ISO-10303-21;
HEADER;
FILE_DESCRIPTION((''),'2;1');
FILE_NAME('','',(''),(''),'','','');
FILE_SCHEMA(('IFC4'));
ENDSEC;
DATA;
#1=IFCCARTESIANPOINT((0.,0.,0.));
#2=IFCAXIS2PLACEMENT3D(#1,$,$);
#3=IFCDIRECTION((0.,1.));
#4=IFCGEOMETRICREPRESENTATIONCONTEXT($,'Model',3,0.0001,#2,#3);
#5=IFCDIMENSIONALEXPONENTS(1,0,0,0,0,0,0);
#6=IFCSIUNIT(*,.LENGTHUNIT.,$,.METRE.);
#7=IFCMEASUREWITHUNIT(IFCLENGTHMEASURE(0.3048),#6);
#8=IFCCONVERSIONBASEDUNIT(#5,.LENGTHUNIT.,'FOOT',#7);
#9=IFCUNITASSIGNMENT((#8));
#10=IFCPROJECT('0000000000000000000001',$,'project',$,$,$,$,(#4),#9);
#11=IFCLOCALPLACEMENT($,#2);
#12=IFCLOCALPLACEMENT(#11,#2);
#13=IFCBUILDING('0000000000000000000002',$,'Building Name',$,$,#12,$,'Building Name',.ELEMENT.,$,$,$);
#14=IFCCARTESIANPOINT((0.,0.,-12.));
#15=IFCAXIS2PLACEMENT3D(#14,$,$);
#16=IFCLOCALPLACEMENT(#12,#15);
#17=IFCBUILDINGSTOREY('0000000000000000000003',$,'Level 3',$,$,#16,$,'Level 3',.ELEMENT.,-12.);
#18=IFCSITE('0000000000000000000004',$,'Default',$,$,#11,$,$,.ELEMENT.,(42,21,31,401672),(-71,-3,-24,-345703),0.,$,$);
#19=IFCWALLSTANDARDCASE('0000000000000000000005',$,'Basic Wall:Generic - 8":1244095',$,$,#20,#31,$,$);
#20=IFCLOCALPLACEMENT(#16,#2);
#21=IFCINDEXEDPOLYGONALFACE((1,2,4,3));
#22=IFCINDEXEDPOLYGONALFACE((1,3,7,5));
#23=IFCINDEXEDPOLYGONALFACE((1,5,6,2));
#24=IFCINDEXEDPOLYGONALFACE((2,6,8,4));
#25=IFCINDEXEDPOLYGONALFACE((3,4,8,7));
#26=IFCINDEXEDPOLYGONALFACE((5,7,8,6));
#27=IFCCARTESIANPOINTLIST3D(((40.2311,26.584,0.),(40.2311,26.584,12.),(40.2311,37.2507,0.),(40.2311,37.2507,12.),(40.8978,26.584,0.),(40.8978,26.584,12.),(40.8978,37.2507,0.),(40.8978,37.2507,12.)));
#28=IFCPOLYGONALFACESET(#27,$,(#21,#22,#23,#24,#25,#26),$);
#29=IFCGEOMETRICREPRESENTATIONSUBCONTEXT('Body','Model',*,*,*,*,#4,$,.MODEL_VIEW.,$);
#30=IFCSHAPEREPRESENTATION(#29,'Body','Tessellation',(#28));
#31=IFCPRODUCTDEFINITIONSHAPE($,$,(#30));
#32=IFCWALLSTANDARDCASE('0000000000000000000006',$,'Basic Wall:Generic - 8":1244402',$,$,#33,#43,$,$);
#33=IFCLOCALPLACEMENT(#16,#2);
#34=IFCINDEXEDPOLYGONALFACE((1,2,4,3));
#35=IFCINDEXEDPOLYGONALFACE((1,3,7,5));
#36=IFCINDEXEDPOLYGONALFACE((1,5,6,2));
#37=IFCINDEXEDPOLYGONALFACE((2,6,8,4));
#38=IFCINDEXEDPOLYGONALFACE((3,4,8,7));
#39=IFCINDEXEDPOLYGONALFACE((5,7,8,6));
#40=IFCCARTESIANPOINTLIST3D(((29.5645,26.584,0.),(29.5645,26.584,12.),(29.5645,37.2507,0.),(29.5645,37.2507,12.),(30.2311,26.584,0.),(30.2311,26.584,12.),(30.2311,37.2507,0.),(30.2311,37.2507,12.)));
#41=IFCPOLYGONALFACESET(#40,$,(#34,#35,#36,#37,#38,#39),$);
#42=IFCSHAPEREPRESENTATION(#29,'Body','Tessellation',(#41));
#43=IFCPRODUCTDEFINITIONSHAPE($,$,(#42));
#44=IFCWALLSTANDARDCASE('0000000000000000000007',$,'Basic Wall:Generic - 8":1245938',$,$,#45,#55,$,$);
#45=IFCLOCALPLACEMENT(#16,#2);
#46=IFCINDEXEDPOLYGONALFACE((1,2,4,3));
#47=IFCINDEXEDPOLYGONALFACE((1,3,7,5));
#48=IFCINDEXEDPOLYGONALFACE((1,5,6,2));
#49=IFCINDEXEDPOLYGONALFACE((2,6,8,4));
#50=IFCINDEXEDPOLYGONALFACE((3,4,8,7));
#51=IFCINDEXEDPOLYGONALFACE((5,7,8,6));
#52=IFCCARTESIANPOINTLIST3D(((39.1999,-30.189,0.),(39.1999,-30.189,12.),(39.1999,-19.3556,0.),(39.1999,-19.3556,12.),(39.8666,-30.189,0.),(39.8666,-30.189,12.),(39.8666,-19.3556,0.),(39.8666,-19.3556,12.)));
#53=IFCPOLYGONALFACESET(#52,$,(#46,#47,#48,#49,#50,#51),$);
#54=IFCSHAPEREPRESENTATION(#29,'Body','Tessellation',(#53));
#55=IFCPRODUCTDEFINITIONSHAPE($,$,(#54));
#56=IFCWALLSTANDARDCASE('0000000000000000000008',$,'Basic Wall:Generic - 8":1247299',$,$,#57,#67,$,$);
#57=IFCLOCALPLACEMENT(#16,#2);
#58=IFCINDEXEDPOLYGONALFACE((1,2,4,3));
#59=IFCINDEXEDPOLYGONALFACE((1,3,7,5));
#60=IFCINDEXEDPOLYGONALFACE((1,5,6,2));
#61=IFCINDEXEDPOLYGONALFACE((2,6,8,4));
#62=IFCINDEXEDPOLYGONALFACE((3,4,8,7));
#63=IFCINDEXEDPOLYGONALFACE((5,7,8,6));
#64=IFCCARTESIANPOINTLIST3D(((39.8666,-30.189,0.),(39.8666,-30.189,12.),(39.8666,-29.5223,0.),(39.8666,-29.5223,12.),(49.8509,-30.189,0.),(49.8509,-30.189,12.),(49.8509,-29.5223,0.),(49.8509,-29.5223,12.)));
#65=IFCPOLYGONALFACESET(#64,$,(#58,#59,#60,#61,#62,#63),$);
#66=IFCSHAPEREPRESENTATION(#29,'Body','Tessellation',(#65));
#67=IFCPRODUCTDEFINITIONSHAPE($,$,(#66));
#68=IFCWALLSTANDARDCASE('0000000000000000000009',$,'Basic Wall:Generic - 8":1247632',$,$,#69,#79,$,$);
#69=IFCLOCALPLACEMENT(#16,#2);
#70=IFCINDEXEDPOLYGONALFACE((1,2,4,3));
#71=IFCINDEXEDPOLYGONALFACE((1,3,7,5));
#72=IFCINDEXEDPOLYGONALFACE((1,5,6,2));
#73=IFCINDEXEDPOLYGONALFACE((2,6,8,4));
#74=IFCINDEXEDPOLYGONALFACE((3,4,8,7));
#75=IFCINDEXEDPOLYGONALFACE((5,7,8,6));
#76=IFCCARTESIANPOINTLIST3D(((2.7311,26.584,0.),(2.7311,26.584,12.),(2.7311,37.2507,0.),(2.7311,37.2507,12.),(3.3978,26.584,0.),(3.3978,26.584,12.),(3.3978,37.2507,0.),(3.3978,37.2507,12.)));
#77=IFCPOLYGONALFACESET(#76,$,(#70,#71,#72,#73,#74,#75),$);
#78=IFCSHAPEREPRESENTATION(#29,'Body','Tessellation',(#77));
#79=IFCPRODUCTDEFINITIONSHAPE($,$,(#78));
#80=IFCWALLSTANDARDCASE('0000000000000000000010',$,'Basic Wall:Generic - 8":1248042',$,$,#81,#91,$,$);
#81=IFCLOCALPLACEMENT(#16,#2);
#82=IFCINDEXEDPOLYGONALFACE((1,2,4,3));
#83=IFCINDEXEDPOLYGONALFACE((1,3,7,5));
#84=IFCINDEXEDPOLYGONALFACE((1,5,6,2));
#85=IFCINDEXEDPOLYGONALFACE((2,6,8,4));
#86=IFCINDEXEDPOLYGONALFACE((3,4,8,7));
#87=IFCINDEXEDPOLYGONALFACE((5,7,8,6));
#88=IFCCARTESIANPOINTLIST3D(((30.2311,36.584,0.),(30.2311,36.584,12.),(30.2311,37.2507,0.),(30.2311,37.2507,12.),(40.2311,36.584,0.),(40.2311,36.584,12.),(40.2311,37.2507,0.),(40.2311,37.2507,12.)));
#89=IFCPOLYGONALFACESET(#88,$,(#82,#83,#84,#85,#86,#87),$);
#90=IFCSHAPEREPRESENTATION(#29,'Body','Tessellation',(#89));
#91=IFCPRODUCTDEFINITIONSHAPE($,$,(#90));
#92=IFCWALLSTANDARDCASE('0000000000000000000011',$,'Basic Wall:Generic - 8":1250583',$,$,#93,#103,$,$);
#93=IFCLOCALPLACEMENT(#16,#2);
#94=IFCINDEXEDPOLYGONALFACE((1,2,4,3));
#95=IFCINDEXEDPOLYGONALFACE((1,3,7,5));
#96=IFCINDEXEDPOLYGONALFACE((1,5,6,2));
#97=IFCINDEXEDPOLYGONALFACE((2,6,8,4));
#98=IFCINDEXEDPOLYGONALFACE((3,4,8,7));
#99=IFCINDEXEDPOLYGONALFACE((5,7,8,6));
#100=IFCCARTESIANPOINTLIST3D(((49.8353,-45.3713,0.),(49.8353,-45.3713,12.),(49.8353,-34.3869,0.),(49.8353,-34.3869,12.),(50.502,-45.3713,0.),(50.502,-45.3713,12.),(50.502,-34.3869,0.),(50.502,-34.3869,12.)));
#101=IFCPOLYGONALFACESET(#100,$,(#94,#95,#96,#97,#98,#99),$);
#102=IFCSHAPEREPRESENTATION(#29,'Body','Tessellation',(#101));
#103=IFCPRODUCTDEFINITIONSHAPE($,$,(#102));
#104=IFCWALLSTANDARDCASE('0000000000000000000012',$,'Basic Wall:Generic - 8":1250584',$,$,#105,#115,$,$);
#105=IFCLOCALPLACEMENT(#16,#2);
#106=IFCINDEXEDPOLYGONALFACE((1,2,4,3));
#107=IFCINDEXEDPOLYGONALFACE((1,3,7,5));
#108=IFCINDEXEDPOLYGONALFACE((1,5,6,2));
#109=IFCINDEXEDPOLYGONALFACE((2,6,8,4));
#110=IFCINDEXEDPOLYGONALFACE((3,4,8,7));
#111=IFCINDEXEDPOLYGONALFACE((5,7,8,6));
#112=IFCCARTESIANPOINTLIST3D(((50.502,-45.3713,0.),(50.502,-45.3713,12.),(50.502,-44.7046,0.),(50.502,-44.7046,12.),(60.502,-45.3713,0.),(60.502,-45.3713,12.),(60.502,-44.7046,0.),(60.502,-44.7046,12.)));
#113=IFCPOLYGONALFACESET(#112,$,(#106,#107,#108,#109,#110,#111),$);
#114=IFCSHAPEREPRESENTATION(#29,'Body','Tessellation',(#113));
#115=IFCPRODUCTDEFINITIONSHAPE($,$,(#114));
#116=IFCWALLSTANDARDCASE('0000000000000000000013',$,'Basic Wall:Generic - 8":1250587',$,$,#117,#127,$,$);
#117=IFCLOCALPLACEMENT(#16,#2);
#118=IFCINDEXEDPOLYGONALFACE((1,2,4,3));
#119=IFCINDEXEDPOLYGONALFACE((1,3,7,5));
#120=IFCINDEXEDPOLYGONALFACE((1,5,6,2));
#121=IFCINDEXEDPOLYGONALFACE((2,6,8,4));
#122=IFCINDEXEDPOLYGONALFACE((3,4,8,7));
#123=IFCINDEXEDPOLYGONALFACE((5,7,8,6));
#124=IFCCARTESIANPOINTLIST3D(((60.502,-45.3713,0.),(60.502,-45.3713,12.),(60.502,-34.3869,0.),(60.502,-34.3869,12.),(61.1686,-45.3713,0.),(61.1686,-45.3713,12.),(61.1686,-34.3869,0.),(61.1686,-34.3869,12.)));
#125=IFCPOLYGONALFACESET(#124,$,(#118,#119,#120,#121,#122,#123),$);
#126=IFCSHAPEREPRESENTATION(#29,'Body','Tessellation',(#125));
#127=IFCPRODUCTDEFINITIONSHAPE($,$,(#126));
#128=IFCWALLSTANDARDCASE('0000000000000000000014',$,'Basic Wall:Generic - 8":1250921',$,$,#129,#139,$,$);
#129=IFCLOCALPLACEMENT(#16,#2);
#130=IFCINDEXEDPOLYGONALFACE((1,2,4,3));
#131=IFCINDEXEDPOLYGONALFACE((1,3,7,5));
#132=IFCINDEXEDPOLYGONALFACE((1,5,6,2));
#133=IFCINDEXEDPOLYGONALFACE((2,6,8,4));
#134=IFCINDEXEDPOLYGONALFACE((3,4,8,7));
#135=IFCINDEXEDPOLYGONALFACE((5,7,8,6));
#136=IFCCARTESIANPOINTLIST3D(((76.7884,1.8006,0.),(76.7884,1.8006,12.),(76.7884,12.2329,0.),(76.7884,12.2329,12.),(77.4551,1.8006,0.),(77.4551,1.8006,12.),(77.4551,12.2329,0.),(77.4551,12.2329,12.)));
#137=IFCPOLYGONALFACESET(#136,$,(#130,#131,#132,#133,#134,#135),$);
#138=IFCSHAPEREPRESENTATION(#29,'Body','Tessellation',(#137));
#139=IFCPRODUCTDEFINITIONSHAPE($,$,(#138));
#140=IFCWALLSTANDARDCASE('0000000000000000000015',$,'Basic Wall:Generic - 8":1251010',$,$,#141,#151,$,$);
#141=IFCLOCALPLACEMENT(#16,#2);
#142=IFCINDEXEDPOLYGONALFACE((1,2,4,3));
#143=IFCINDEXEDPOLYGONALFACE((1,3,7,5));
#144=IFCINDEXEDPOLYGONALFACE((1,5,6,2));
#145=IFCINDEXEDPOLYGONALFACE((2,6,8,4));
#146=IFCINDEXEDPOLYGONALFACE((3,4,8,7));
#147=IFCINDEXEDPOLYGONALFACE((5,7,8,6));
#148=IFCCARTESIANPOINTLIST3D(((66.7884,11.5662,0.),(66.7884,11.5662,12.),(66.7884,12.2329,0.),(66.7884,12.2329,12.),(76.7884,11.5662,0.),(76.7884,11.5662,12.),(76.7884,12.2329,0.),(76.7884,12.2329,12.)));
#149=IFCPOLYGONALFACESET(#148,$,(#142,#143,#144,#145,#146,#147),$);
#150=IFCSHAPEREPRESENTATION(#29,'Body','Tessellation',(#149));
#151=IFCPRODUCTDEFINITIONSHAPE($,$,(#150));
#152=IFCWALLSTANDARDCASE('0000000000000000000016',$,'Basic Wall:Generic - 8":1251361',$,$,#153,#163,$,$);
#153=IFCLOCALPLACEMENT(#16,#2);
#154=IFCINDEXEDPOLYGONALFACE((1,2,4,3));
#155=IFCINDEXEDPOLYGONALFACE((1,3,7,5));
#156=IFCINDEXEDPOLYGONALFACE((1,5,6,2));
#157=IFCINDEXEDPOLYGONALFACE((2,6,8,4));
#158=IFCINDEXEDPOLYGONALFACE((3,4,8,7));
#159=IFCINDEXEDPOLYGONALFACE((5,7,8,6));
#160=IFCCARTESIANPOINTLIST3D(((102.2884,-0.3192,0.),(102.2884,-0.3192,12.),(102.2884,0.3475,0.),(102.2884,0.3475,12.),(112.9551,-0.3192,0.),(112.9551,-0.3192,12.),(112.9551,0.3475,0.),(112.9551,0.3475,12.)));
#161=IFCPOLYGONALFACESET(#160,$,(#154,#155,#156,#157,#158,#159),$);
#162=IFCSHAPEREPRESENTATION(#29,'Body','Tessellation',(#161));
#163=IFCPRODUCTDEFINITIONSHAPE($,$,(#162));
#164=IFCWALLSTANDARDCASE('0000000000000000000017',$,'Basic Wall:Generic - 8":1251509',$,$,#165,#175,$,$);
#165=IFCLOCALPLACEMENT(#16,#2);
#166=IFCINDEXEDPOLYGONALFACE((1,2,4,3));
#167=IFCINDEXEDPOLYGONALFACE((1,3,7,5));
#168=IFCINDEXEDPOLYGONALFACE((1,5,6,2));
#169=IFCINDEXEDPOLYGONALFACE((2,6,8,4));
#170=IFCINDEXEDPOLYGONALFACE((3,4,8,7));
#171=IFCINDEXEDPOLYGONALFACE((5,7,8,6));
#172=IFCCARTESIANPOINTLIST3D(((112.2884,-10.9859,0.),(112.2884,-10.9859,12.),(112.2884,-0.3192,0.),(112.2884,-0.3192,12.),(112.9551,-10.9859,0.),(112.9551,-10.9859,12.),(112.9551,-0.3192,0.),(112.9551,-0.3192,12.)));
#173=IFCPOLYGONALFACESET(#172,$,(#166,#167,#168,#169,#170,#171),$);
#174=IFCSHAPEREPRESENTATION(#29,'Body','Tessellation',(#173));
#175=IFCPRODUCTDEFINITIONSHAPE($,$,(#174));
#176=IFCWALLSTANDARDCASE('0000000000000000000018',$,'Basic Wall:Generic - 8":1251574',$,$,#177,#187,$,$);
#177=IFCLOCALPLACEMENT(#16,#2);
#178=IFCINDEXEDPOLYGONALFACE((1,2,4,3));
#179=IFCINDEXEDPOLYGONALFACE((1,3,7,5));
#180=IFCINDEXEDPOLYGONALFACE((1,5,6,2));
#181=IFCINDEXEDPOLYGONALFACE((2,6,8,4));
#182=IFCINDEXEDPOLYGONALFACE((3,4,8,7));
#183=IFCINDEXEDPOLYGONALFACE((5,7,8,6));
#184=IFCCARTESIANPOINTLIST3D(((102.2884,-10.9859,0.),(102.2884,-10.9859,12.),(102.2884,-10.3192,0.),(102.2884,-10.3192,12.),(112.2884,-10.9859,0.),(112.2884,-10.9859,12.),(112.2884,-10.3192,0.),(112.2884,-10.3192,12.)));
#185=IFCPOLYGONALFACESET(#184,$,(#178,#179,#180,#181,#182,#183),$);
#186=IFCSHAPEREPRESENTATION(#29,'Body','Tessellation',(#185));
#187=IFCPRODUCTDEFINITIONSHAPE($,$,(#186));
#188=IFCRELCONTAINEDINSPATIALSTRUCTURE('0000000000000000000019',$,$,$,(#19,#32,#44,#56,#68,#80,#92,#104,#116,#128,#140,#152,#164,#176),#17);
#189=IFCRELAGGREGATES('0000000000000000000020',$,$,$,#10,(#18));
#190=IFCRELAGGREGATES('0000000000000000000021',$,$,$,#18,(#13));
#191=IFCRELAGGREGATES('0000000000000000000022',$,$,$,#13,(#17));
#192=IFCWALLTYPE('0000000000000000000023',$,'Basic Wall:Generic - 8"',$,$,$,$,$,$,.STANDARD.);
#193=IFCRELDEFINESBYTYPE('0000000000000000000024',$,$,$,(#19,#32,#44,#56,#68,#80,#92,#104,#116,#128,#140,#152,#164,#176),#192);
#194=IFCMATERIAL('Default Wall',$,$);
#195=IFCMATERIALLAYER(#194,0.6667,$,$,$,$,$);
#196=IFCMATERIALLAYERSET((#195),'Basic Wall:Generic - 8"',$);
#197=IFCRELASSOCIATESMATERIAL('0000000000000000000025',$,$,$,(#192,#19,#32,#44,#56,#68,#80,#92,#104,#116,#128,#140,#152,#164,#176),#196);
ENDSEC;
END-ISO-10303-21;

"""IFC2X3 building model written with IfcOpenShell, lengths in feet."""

from ifc_helpers import new_model, entity, si_unit, converted_unit, direction, frame, frame_2d, origin, place, context, subcontext, project, spatial, rectangle, extrude, material, layer, layer_set, layer_usage, type_object, element, save


model = new_model("IFC2X3")

# Units and contexts
model_context = context("Model", 3, precision=0.0001, world=origin(), true_north=direction((0.0, 1.0)))
body_context = subcontext(model_context, "Body", "Model", "MODEL_VIEW")
ifc_project = project(units=[converted_unit("LENGTHUNIT", "FOOT", entity("IfcLengthMeasure", 0.3048), si_unit("LENGTHUNIT", "METRE"), dimensions=[1, 0, 0, 0, 0, 0, 0])], contexts=[model_context])

# Site, building, storey
site_placement = place(None, origin())
site = spatial("IfcSite", under=ifc_project, at=site_placement, Name="Default", CompositionType="ELEMENT", RefLatitude=(42, 21, 31, 401672), RefLongitude=(-71, -3, -24, -345703), RefElevation=0.0)
building_placement = place(site_placement, origin())
building = spatial("IfcBuilding", under=site, at=building_placement, Name="Building Name", LongName="Building Name", CompositionType="ELEMENT")
storey_placement = place(building_placement, frame((0.0, 0.0, -12.0)))
storey = spatial("IfcBuildingStorey", under=building, at=storey_placement, Name="Level 3", LongName="Level 3", CompositionType="ELEMENT", Elevation=-12.0)

# Walls
ifc_material_1 = material(Name="Default Wall")
ifc_layer_1 = layer(ifc_material_1, 0.6667)
ifc_layer_set_1 = layer_set([ifc_layer_1], Name="Basic Wall:Generic - 8\"")
ifc_layer_usage_1 = layer_usage(ifc_layer_set_1, "AXIS2", "POSITIVE", -0.3333)
wall_type_1 = type_object("IfcWallType", Name="Basic Wall:Generic - 8\"", PredefinedType="STANDARD", material=ifc_layer_set_1)
wall_1_placement = place(storey_placement, frame((40.5645, 26.584, 0.0), z_axis=(0.0, 0.0, 1.0), x_axis=(0.0, 1.0, 0.0)))
element("IfcWallStandardCase", 1, at=wall_1_placement, inside=storey, type_object=wall_type_1, material=ifc_layer_usage_1, Name="Basic Wall:Generic - 8\":1244095", context=body_context, shape_type="SweptSolid", body=[
    extrude(rectangle(XDim=10.6667, YDim=0.6667, at=frame_2d((5.3333, 0.0), x_axis=(-1.0, 0.0))), origin(), (0.0, 0.0, 1.0), 12.0),
])
ifc_layer_usage_2 = layer_usage(ifc_layer_set_1, "AXIS2", "NEGATIVE", 0.3333)
wall_2_placement = place(storey_placement, frame((29.8978, 26.584, 0.0), z_axis=(0.0, 0.0, 1.0), x_axis=(0.0, 1.0, 0.0)))
element("IfcWallStandardCase", 2, at=wall_2_placement, inside=storey, type_object=wall_type_1, material=ifc_layer_usage_2, Name="Basic Wall:Generic - 8\":1244402", context=body_context, shape_type="SweptSolid", body=[
    extrude(rectangle(XDim=10.6667, YDim=0.6667, at=frame_2d((5.3333, 0.0), x_axis=(-1.0, 0.0))), origin(), (0.0, 0.0, 1.0), 12.0),
])
ifc_layer_usage_3 = layer_usage(ifc_layer_set_1, "AXIS2", "POSITIVE", -0.3333)
wall_3_placement = place(storey_placement, frame((39.5332, -19.3556, 0.0), z_axis=(0.0, 0.0, 1.0), x_axis=(0.0, -1.0, 0.0)))
element("IfcWallStandardCase", 3, at=wall_3_placement, inside=storey, type_object=wall_type_1, material=ifc_layer_usage_3, Name="Basic Wall:Generic - 8\":1245938", context=body_context, shape_type="SweptSolid", body=[
    extrude(rectangle(XDim=10.8333, YDim=0.6667, at=frame_2d((5.4167, 0.0), x_axis=(-1.0, 0.0))), origin(), (0.0, 0.0, 1.0), 12.0),
])
ifc_layer_usage_4 = layer_usage(ifc_layer_set_1, "AXIS2", "NEGATIVE", 0.3333)
wall_4_placement = place(storey_placement, frame((39.8666, -29.8556, 0.0)))
element("IfcWallStandardCase", 4, at=wall_4_placement, inside=storey, type_object=wall_type_1, material=ifc_layer_usage_4, Name="Basic Wall:Generic - 8\":1247299", context=body_context, shape_type="SweptSolid", body=[
    extrude(rectangle(XDim=9.9844, YDim=0.6667, at=frame_2d((4.9922, 0.0), x_axis=(-1.0, 0.0))), origin(), (0.0, 0.0, 1.0), 12.0),
])
ifc_layer_usage_5 = layer_usage(ifc_layer_set_1, "AXIS2", "NEGATIVE", 0.3333)
wall_5_placement = place(storey_placement, frame((3.0645, 37.2507, 0.0), z_axis=(0.0, 0.0, 1.0), x_axis=(0.0, -1.0, 0.0)))
element("IfcWallStandardCase", 5, at=wall_5_placement, inside=storey, type_object=wall_type_1, material=ifc_layer_usage_5, Name="Basic Wall:Generic - 8\":1247632", context=body_context, shape_type="SweptSolid", body=[
    extrude(rectangle(XDim=10.6667, YDim=0.6667, at=frame_2d((5.3333, 0.0), x_axis=(-1.0, 0.0))), origin(), (0.0, 0.0, 1.0), 12.0),
])
ifc_layer_usage_6 = layer_usage(ifc_layer_set_1, "AXIS2", "NEGATIVE", 0.3333)
wall_6_placement = place(storey_placement, frame((30.2311, 36.9174, 0.0)))
element("IfcWallStandardCase", 6, at=wall_6_placement, inside=storey, type_object=wall_type_1, material=ifc_layer_usage_6, Name="Basic Wall:Generic - 8\":1248042", context=body_context, shape_type="SweptSolid", body=[
    extrude(rectangle(XDim=10.0, YDim=0.6667, at=frame_2d((5.0, 0.0), x_axis=(-1.0, 0.0))), origin(), (0.0, 0.0, 1.0), 12.0),
])
ifc_layer_usage_7 = layer_usage(ifc_layer_set_1, "AXIS2", "POSITIVE", -0.3333)
wall_7_placement = place(storey_placement, frame((50.1686, -34.3869, 0.0), z_axis=(0.0, 0.0, 1.0), x_axis=(0.0, -1.0, 0.0)))
element("IfcWallStandardCase", 7, at=wall_7_placement, inside=storey, type_object=wall_type_1, material=ifc_layer_usage_7, Name="Basic Wall:Generic - 8\":1250583", context=body_context, shape_type="SweptSolid", body=[
    extrude(rectangle(XDim=10.9844, YDim=0.6667, at=frame_2d((5.4922, 0.0), x_axis=(-1.0, 0.0))), origin(), (0.0, 0.0, 1.0), 12.0),
])
ifc_layer_usage_8 = layer_usage(ifc_layer_set_1, "AXIS2", "POSITIVE", -0.3333)
wall_8_placement = place(storey_placement, frame((50.502, -45.0379, 0.0)))
element("IfcWallStandardCase", 8, at=wall_8_placement, inside=storey, type_object=wall_type_1, material=ifc_layer_usage_8, Name="Basic Wall:Generic - 8\":1250584", context=body_context, shape_type="SweptSolid", body=[
    extrude(rectangle(XDim=10.0, YDim=0.6667, at=frame_2d((5.0, 0.0), x_axis=(-1.0, 0.0))), origin(), (0.0, 0.0, 1.0), 12.0),
])
ifc_layer_usage_9 = layer_usage(ifc_layer_set_1, "AXIS2", "NEGATIVE", 0.3333)
wall_9_placement = place(storey_placement, frame((60.8353, -34.3869, 0.0), z_axis=(0.0, 0.0, 1.0), x_axis=(0.0, -1.0, 0.0)))
element("IfcWallStandardCase", 9, at=wall_9_placement, inside=storey, type_object=wall_type_1, material=ifc_layer_usage_9, Name="Basic Wall:Generic - 8\":1250587", context=body_context, shape_type="SweptSolid", body=[
    extrude(rectangle(XDim=10.9844, YDim=0.6667, at=frame_2d((5.4922, 0.0), x_axis=(-1.0, 0.0))), origin(), (0.0, 0.0, 1.0), 12.0),
])
ifc_layer_usage_10 = layer_usage(ifc_layer_set_1, "AXIS2", "NEGATIVE", 0.3333)
wall_10_placement = place(storey_placement, frame((77.1218, 1.8006, 0.0), z_axis=(0.0, 0.0, 1.0), x_axis=(0.0, 1.0, 0.0)))
element("IfcWallStandardCase", 10, at=wall_10_placement, inside=storey, type_object=wall_type_1, material=ifc_layer_usage_10, Name="Basic Wall:Generic - 8\":1250921", context=body_context, shape_type="SweptSolid", body=[
    extrude(rectangle(XDim=10.4323, YDim=0.6667, at=frame_2d((5.2161, 0.0), x_axis=(-1.0, 0.0))), origin(), (0.0, 0.0, 1.0), 12.0),
])
ifc_layer_usage_11 = layer_usage(ifc_layer_set_1, "AXIS2", "NEGATIVE", 0.3333)
wall_11_placement = place(storey_placement, frame((76.7884, 11.8996, 0.0), z_axis=(0.0, 0.0, 1.0), x_axis=(-1.0, 0.0, 0.0)))
element("IfcWallStandardCase", 11, at=wall_11_placement, inside=storey, type_object=wall_type_1, material=ifc_layer_usage_11, Name="Basic Wall:Generic - 8\":1251010", context=body_context, shape_type="SweptSolid", body=[
    extrude(rectangle(XDim=10.0, YDim=0.6667, at=frame_2d((5.0, 0.0), x_axis=(-1.0, 0.0))), origin(), (0.0, 0.0, 1.0), 12.0),
])
ifc_layer_usage_12 = layer_usage(ifc_layer_set_1, "AXIS2", "NEGATIVE", 0.3333)
wall_12_placement = place(storey_placement, frame((102.2884, 0.0141, 0.0)))
element("IfcWallStandardCase", 12, at=wall_12_placement, inside=storey, type_object=wall_type_1, material=ifc_layer_usage_12, Name="Basic Wall:Generic - 8\":1251361", context=body_context, shape_type="SweptSolid", body=[
    extrude(rectangle(XDim=10.6667, YDim=0.6667, at=frame_2d((5.3333, 0.0), x_axis=(-1.0, 0.0))), origin(), (0.0, 0.0, 1.0), 12.0),
])
ifc_layer_usage_13 = layer_usage(ifc_layer_set_1, "AXIS2", "POSITIVE", -0.3333)
wall_13_placement = place(storey_placement, frame((112.6218, -0.3192, 0.0), z_axis=(0.0, 0.0, 1.0), x_axis=(0.0, -1.0, 0.0)))
element("IfcWallStandardCase", 13, at=wall_13_placement, inside=storey, type_object=wall_type_1, material=ifc_layer_usage_13, Name="Basic Wall:Generic - 8\":1251509", context=body_context, shape_type="SweptSolid", body=[
    extrude(rectangle(XDim=10.6667, YDim=0.6667, at=frame_2d((5.3333, 0.0), x_axis=(-1.0, 0.0))), origin(), (0.0, 0.0, 1.0), 12.0),
])
ifc_layer_usage_14 = layer_usage(ifc_layer_set_1, "AXIS2", "NEGATIVE", 0.3333)
wall_14_placement = place(storey_placement, frame((112.2884, -10.6525, 0.0), z_axis=(0.0, 0.0, 1.0), x_axis=(-1.0, 0.0, 0.0)))
element("IfcWallStandardCase", 14, at=wall_14_placement, inside=storey, type_object=wall_type_1, material=ifc_layer_usage_14, Name="Basic Wall:Generic - 8\":1251574", context=body_context, shape_type="SweptSolid", body=[
    extrude(rectangle(XDim=10.0, YDim=0.6667, at=frame_2d((5.0, 0.0), x_axis=(-1.0, 0.0))), origin(), (0.0, 0.0, 1.0), 12.0),
])

save(model, "model.ifc")
